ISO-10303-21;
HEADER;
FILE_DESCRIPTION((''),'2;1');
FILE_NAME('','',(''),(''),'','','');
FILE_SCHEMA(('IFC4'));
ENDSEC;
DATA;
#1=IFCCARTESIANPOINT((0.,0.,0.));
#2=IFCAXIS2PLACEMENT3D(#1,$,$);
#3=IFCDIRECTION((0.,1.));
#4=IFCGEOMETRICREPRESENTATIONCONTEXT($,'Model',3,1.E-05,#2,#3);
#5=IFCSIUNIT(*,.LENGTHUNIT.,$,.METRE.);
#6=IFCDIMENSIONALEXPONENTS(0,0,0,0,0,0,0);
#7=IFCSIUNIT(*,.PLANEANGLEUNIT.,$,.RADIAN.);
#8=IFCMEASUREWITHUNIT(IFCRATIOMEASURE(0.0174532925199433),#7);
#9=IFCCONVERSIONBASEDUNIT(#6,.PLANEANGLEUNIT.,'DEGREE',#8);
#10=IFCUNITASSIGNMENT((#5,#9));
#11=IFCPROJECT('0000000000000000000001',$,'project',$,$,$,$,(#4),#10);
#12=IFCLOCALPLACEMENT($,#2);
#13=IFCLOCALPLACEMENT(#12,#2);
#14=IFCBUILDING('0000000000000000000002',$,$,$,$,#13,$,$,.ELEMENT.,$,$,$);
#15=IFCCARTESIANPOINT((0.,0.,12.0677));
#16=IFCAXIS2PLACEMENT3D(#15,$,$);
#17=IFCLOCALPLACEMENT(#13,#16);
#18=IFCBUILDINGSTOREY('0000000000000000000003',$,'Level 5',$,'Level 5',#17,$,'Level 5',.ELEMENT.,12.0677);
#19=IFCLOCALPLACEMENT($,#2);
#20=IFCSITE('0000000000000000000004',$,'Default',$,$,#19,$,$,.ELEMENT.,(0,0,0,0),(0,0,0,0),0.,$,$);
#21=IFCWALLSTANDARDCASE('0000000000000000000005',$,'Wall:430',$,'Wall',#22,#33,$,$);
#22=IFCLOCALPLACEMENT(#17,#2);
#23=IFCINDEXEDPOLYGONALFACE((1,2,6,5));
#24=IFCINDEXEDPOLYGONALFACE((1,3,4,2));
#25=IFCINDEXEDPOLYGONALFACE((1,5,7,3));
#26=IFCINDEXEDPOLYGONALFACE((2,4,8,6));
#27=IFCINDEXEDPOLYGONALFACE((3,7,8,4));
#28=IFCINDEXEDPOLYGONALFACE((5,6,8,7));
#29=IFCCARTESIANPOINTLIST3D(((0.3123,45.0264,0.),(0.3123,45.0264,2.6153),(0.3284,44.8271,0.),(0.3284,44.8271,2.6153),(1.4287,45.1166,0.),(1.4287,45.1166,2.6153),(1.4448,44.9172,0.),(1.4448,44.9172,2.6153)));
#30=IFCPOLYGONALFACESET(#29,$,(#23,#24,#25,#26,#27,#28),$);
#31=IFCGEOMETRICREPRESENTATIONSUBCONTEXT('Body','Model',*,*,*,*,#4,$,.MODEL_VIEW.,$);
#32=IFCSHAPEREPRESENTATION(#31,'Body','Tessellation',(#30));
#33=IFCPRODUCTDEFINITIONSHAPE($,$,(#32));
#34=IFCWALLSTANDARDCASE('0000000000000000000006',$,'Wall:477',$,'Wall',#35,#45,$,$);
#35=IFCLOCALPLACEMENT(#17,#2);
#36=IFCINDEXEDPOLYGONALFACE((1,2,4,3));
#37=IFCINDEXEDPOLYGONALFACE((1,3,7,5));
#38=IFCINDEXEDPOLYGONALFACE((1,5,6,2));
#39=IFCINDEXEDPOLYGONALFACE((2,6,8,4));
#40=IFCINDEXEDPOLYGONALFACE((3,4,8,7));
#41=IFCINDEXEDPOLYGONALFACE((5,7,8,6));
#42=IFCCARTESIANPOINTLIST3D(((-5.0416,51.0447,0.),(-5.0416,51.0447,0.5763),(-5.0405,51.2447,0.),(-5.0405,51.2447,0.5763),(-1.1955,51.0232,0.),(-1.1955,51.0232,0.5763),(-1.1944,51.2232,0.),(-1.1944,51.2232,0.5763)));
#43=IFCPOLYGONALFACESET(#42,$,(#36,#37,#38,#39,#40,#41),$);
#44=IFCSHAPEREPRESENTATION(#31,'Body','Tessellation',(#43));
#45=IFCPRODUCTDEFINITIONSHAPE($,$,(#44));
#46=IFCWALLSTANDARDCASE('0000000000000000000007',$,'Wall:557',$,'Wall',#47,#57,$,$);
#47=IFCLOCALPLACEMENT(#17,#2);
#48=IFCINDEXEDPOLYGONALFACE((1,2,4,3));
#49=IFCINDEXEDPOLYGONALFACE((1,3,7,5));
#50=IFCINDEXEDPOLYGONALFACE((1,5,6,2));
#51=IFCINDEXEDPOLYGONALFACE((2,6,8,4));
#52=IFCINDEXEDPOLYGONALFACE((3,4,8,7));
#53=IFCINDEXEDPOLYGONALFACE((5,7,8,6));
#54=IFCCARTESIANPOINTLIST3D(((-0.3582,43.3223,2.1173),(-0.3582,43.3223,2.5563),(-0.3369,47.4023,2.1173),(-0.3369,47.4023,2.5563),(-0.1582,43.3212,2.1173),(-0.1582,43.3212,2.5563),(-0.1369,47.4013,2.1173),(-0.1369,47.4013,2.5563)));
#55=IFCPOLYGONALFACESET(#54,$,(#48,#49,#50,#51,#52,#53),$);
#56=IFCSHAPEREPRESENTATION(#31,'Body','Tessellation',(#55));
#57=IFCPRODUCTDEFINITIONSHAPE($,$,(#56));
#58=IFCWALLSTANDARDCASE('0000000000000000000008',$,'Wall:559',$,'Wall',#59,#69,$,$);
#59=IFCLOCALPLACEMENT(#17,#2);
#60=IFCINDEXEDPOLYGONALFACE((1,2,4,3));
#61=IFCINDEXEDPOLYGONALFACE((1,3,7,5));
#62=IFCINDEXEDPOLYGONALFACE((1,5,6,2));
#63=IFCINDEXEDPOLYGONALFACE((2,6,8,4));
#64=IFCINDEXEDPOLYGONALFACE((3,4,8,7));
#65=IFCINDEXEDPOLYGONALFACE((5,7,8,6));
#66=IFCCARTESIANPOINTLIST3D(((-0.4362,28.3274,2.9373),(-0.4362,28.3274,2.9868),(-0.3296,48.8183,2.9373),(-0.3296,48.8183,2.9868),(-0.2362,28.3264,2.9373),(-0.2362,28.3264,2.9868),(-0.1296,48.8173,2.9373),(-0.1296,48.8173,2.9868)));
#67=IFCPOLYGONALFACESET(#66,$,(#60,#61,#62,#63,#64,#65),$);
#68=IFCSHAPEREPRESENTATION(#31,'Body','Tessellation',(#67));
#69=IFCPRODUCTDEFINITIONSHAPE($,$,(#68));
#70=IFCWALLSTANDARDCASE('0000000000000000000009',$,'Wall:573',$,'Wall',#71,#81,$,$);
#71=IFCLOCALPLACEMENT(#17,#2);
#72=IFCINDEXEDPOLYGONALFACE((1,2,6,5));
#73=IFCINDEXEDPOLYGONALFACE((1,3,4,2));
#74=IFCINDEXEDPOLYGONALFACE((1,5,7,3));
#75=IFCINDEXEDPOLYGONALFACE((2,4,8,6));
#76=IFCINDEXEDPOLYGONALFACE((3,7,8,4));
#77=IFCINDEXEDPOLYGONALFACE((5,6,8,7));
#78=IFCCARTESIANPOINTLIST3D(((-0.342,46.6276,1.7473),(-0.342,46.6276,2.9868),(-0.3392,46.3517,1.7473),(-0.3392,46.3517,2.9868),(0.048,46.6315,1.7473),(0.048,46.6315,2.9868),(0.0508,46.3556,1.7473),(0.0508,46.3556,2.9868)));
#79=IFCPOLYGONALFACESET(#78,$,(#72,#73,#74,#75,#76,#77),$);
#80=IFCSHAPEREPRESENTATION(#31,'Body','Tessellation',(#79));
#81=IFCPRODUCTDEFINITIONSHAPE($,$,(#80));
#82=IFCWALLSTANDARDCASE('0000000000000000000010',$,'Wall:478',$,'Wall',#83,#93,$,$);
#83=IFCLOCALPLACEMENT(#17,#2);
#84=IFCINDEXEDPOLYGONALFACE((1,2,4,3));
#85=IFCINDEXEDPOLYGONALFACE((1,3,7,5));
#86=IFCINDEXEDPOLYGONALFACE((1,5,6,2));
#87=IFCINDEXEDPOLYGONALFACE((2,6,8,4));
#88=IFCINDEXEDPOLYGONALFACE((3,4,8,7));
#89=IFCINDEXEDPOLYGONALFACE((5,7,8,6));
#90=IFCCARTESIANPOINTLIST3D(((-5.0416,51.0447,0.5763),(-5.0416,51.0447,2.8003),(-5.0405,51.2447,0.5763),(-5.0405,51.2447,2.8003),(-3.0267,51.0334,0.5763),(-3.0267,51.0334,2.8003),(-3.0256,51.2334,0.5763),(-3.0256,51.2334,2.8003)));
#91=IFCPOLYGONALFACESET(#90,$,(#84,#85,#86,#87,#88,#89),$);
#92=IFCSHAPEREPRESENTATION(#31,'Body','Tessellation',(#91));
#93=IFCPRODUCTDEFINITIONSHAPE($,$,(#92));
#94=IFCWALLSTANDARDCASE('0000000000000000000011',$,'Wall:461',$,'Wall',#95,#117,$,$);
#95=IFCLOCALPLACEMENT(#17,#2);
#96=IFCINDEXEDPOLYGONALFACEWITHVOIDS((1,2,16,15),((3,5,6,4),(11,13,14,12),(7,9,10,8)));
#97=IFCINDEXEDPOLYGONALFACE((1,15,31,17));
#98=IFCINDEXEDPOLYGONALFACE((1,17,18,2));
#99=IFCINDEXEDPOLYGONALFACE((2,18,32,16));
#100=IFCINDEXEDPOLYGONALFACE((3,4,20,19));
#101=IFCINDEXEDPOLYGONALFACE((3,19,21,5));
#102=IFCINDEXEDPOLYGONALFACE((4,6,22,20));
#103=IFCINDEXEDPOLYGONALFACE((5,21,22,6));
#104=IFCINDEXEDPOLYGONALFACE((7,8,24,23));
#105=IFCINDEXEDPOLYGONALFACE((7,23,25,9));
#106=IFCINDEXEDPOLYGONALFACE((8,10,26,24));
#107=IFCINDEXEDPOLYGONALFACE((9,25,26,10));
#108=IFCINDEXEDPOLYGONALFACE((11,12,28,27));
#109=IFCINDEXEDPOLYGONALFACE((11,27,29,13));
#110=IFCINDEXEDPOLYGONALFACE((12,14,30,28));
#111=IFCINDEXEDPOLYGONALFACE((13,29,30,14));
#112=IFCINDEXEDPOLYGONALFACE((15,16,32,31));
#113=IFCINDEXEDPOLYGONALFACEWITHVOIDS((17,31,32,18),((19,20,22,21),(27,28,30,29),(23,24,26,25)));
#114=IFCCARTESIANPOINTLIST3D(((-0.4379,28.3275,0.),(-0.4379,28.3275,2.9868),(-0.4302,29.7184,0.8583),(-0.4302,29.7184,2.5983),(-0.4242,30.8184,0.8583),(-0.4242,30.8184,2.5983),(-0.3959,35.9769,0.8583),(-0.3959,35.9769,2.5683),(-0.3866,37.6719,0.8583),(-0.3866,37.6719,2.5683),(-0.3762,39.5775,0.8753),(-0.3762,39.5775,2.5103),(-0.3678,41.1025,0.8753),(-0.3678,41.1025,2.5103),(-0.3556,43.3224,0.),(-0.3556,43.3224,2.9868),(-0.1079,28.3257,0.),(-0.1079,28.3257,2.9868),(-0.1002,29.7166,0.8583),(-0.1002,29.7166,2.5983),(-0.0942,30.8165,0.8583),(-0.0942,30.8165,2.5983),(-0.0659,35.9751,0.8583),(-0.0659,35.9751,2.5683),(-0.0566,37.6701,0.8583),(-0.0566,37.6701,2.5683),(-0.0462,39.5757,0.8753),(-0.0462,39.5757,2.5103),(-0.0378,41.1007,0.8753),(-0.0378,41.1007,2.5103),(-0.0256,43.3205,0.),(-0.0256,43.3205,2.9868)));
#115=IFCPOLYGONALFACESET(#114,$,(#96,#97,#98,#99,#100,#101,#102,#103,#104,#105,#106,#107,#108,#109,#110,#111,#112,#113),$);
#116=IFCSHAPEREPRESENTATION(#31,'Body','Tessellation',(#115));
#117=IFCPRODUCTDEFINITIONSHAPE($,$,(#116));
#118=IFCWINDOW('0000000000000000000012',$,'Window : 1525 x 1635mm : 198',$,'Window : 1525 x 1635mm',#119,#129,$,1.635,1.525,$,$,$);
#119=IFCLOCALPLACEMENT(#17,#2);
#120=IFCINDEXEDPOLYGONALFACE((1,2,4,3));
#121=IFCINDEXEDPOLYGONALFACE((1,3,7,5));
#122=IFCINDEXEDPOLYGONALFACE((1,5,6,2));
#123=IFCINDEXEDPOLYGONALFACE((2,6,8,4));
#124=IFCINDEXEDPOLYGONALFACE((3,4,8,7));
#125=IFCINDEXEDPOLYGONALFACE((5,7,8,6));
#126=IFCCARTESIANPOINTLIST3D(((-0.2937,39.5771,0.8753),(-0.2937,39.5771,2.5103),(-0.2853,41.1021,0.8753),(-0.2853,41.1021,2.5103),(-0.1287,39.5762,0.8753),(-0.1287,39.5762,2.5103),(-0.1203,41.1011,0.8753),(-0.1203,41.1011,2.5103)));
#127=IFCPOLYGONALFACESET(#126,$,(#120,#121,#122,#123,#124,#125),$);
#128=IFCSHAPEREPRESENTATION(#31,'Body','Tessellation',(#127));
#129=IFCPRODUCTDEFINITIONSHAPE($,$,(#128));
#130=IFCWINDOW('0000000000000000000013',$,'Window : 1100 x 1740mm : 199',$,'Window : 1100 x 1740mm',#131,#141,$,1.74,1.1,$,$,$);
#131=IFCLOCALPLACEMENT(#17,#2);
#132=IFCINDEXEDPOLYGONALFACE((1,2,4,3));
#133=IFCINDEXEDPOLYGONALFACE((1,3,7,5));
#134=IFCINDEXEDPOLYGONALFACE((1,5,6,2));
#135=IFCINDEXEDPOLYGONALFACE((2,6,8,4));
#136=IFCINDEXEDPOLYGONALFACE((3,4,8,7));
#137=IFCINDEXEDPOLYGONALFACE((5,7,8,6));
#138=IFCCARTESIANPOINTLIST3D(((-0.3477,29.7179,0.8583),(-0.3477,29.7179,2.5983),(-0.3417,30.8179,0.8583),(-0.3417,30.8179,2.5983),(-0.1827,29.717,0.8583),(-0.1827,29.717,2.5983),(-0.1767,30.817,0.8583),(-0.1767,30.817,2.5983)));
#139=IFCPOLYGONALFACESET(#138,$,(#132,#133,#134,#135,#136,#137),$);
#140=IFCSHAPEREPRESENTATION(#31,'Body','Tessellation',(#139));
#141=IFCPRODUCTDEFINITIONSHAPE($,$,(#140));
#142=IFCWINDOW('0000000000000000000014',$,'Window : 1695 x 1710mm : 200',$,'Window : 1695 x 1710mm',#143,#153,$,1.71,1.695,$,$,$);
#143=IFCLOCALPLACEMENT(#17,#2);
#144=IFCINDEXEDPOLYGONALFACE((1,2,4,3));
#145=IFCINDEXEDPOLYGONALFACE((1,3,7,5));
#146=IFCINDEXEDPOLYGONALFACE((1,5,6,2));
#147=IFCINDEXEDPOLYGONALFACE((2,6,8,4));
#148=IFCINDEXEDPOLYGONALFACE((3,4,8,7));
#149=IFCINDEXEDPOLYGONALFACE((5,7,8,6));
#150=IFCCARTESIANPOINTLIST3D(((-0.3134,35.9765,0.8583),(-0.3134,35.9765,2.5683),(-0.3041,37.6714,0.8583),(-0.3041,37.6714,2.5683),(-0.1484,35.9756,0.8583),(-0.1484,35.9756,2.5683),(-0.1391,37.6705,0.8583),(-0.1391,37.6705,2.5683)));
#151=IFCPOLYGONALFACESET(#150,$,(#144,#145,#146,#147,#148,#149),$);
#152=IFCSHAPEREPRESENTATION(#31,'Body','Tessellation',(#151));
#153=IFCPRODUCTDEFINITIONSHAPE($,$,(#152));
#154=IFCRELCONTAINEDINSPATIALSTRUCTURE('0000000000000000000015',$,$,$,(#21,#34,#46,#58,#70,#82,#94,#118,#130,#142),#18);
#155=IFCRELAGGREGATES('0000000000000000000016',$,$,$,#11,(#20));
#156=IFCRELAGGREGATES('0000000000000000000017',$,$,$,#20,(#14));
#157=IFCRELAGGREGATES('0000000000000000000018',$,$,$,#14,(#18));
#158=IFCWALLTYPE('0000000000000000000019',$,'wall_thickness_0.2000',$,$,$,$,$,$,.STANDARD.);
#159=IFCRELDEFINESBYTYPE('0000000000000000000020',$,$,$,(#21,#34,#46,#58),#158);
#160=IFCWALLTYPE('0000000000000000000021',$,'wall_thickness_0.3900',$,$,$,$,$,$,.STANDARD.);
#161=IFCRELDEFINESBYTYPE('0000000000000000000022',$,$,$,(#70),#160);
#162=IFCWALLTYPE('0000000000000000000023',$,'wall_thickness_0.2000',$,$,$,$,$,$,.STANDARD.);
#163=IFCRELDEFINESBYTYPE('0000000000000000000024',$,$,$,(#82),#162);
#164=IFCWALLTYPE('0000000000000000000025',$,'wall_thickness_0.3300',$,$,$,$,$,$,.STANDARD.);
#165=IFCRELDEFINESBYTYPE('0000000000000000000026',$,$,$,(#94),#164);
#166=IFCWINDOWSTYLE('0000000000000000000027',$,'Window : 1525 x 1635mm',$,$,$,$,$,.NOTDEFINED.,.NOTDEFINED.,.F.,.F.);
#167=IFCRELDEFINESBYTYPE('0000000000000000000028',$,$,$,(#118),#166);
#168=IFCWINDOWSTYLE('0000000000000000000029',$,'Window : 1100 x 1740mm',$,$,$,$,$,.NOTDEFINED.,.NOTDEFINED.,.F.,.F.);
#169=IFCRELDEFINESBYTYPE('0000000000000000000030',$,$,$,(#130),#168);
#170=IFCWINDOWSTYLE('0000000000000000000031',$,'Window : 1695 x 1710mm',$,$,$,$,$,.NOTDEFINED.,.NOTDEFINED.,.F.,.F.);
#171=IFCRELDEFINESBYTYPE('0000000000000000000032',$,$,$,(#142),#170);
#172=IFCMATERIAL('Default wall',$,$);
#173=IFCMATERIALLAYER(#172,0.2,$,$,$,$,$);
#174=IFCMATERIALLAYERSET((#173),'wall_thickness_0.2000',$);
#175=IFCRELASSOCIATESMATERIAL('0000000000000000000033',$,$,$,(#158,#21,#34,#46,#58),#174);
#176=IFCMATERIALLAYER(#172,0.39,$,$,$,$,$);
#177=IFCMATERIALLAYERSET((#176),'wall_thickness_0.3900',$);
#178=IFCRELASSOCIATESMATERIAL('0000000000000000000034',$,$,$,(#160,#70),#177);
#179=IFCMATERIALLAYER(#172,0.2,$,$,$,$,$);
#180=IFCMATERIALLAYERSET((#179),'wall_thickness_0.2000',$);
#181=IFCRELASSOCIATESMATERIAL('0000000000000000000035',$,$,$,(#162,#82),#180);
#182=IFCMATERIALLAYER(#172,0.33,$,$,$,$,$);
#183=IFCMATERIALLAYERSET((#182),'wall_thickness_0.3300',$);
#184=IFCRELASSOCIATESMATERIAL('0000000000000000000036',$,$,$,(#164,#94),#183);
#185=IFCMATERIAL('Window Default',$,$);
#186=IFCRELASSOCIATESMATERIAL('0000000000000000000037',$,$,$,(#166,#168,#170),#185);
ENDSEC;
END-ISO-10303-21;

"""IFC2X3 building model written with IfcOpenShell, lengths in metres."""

from ifc_helpers import new_model, entity, si_unit, converted_unit, direction, frame, frame_2d, origin, origin_2d_with_axis, place, context, subcontext, project, spatial, polyline, rectangle, outline, extrude, source, transform, mapped, material, layer, layer_set, layer_usage, type_object, type_shapes, element, fill, save


model = new_model("IFC2X3")

# Units and contexts
model_context = context("Model", 3, precision=1e-05, world=origin(), true_north=direction((0.0, 1.0)))
body_context = subcontext(model_context, "Body", "Model", "MODEL_VIEW")
ifc_project = project(units=[si_unit("LENGTHUNIT", "METRE"), converted_unit("PLANEANGLEUNIT", "DEGREE", entity("IfcRatioMeasure", 0.0174532925199433), si_unit("PLANEANGLEUNIT", "RADIAN"), dimensions=[0, 0, 0, 0, 0, 0, 0])], contexts=[model_context])

# Site, building, storey
site_placement = place(None, origin())
site = spatial("IfcSite", under=ifc_project, at=site_placement, Name="Default", CompositionType="ELEMENT", RefLatitude=(0, 0, 0, 0), RefLongitude=(0, 0, 0, 0), RefElevation=0.0)
placement_1 = place(None, origin())
building_placement = place(placement_1, origin())
building = spatial("IfcBuilding", under=site, at=building_placement, CompositionType="ELEMENT")
storey_placement = place(building_placement, frame((0.0, 0.0, 12.0677)))
storey = spatial("IfcBuildingStorey", under=building, at=storey_placement, Name="Level 5", ObjectType="Level 5", LongName="Level 5", CompositionType="ELEMENT", Elevation=12.0677)

# Walls
ifc_material_1 = material(Name="Default wall")
ifc_layer_1 = layer(ifc_material_1, 0.2)
ifc_layer_set_1 = layer_set([ifc_layer_1], Name="wall_thickness_0.2000")
ifc_layer_usage_1 = layer_usage(ifc_layer_set_1, "AXIS2", "POSITIVE", -0.1)
wall_type_1 = type_object("IfcWallType", Name="wall_thickness_0.2000", PredefinedType="STANDARD", material=ifc_layer_set_1)
wall_1_placement = place(storey_placement, frame((0.3203, 44.9268, 0.0), z_axis=(0.0, 0.0, 1.0), x_axis=(0.996755, 0.080497, 0.0)))
element("IfcWallStandardCase", 1, at=wall_1_placement, inside=storey, type_object=wall_type_1, material=ifc_layer_usage_1, Name="Wall:430", ObjectType="Wall", context=body_context, shape_type="SweptSolid", body=[
    extrude(outline(polyline([(1.1201, -0.1), (1.1201, 0.1), (0.0, 0.1), (0.0, -0.1), (1.1201, -0.1)])), origin(), (0.0, 0.0, 1.0), 2.6153),
])
wall_2_placement = place(storey_placement, frame((-5.041, 51.1447, 0.0), z_axis=(0.0, 0.0, 1.0), x_axis=(0.999984, -0.005584, 0.0)))
element("IfcWallStandardCase", 2, at=wall_2_placement, inside=storey, type_object=wall_type_1, material=ifc_layer_usage_1, Name="Wall:477", ObjectType="Wall", context=body_context, shape_type="SweptSolid", body=[
    extrude(outline(polyline([(3.8461, -0.1), (3.8461, 0.1), (0.0, 0.1), (0.0, -0.1), (3.8461, -0.1)])), origin(), (0.0, 0.0, 1.0), 0.5763),
])
placement_2 = place(building_placement, frame((0.0, 0.0, 14.185)))
wall_3_placement = place(placement_2, frame((-0.2369, 47.4018, 0.0), z_axis=(0.0, 0.0, 1.0), x_axis=(-0.005207, -0.999986, 0.0)))
element("IfcWallStandardCase", 3, at=wall_3_placement, inside=storey, type_object=wall_type_1, material=ifc_layer_usage_1, Name="Wall:557", ObjectType="Wall", context=body_context, shape_type="SweptSolid", body=[
    extrude(outline(polyline([(4.0801, -0.1), (4.0801, 0.1), (0.0, 0.1), (0.0, -0.1), (4.0801, -0.1)])), origin(), (0.0, 0.0, 1.0), 0.439),
])
placement_3 = place(building_placement, frame((0.0, 0.0, 15.005)))
wall_4_placement = place(placement_3, frame((-0.2296, 48.8178, 0.0), z_axis=(0.0, 0.0, 1.0), x_axis=(-0.005207, -0.999986, 0.0)))
element("IfcWallStandardCase", 4, at=wall_4_placement, inside=storey, type_object=wall_type_1, material=ifc_layer_usage_1, Name="Wall:559", ObjectType="Wall", context=body_context, shape_type="SweptSolid", body=[
    extrude(outline(polyline([(20.4912, -0.1), (20.4912, 0.1), (0.0, 0.1), (0.0, -0.1), (20.4912, -0.1)])), origin(), (0.0, 0.0, 1.0), 0.0495),
])
ifc_layer_2 = layer(ifc_material_1, 0.39)
ifc_layer_set_2 = layer_set([ifc_layer_2], Name="wall_thickness_0.3900")
ifc_layer_usage_2 = layer_usage(ifc_layer_set_2, "AXIS2", "POSITIVE", -0.195)
wall_type_2 = type_object("IfcWallType", Name="wall_thickness_0.3900", PredefinedType="STANDARD", material=ifc_layer_set_2)
placement_4 = place(building_placement, frame((0.0, 0.0, 13.815)))
wall_5_placement = place(placement_4, frame((-0.147, 46.6296, 0.0), z_axis=(0.0, 0.0, 1.0), x_axis=(0.01007, -0.999949, 0.0)))
element("IfcWallStandardCase", 5, at=wall_5_placement, inside=storey, type_object=wall_type_2, material=ifc_layer_usage_2, Name="Wall:573", ObjectType="Wall", context=body_context, shape_type="SweptSolid", body=[
    extrude(outline(polyline([(0.276, -0.195), (0.276, 0.195), (0.0, 0.195), (0.0, -0.195), (0.276, -0.195)])), origin(), (0.0, 0.0, 1.0), 1.2395),
])
ifc_layer_3 = layer(ifc_material_1, 0.2)
ifc_layer_set_3 = layer_set([ifc_layer_3], Name="wall_thickness_0.2000")
ifc_layer_usage_3 = layer_usage(ifc_layer_set_3, "AXIS2", "POSITIVE", -0.1)
wall_type_3 = type_object("IfcWallType", Name="wall_thickness_0.2000", PredefinedType="STANDARD", material=ifc_layer_set_3)
placement_5 = place(building_placement, frame((0.0, 0.0, 12.644)))
wall_6_placement = place(placement_5, frame((-5.041, 51.1447, 0.0), z_axis=(0.0, 0.0, 1.0), x_axis=(0.999984, -0.005585, 0.0)))
element("IfcWallStandardCase", 6, at=wall_6_placement, inside=storey, type_object=wall_type_3, material=ifc_layer_usage_3, Name="Wall:478", ObjectType="Wall", context=body_context, shape_type="SweptSolid", body=[
    extrude(outline(polyline([(2.0149, -0.1), (2.0149, 0.1), (0.0, 0.1), (0.0, -0.1), (2.0149, -0.1)])), origin(), (0.0, 0.0, 1.0), 2.224),
])

# Wall, openings, windows
ifc_layer_4 = layer(ifc_material_1, 0.33)
ifc_layer_set_4 = layer_set([ifc_layer_4], Name="wall_thickness_0.3300")
ifc_layer_usage_4 = layer_usage(ifc_layer_set_4, "AXIS2", "POSITIVE", -0.165)
wall_type_4 = type_object("IfcWallType", Name="wall_thickness_0.3300", PredefinedType="STANDARD", material=ifc_layer_set_4)
wall_7_placement = place(storey_placement, frame((-0.1906, 43.3215, 0.0), z_axis=(0.0, 0.0, 1.0), x_axis=(-0.005485, -0.999985, 0.0)))
wall_7 = element("IfcWallStandardCase", 7, at=wall_7_placement, inside=storey, type_object=wall_type_4, material=ifc_layer_usage_4, Name="Wall:461", ObjectType="Wall", context=body_context, shape_type="SweptSolid", body=[
    extrude(outline(polyline([(14.995, -0.165), (14.995, 0.165), (0.0, 0.165), (0.0, -0.165), (14.995, -0.165)])), origin(), (0.0, 0.0, 1.0), 2.9868),
])
opening_1_placement = place(wall_7_placement, frame((2.2199, -0.165, 0.8753)))
opening_1 = element("IfcOpeningElement", 8, at=opening_1_placement, cuts=wall_7, ObjectType="Opening", context=body_context, shape_type="SweptSolid", body=[
    extrude(rectangle(XDim=1.525, YDim=1.635, at=frame_2d((0.8175, 0.7625), x_axis=(0.0, 1.0))), frame((0.0, 0.0, 0.0), z_axis=(0.0, 1.0, 0.0), x_axis=(0.0, 0.0, 1.0)), (0.0, 0.0, 1.0), 0.33),
])
opening_2_placement = place(wall_7_placement, frame((12.5042, -0.165, 0.8583)))
opening_2 = element("IfcOpeningElement", 9, at=opening_2_placement, cuts=wall_7, ObjectType="Opening", context=body_context, shape_type="SweptSolid", body=[
    extrude(rectangle(XDim=1.1, YDim=1.74, at=frame_2d((0.87, 0.55), x_axis=(0.0, 1.0))), frame((0.0, 0.0, 0.0), z_axis=(0.0, 1.0, 0.0), x_axis=(0.0, 0.0, 1.0)), (0.0, 0.0, 1.0), 0.33),
])
opening_3_placement = place(wall_7_placement, frame((5.6505, -0.165, 0.8583)))
opening_3 = element("IfcOpeningElement", 10, at=opening_3_placement, cuts=wall_7, ObjectType="Opening", context=body_context, shape_type="SweptSolid", body=[
    extrude(rectangle(XDim=1.695, YDim=1.71, at=frame_2d((0.855, 0.8475), x_axis=(0.0, 1.0))), frame((0.0, 0.0, 0.0), z_axis=(0.0, 1.0, 0.0), x_axis=(0.0, 0.0, 1.0)), (0.0, 0.0, 1.0), 0.33),
])
ifc_material_2 = material(Name="Window Default")
window_style_1 = type_object("IfcWindowStyle", Name="Window : 1525 x 1635mm", ConstructionType="NOTDEFINED", OperationType="NOTDEFINED", ParameterTakesPrecedence=False, Sizeable=False, material=ifc_material_2)
shared_shape_1 = source(origin(), body_context, "Body", "SweptSolid", [
    extrude(rectangle(XDim=0.165, YDim=1.525, at=origin_2d_with_axis()), frame((0.7625, 0.165, 0.0), z_axis=(0.0, 0.0, 1.0), x_axis=(0.0, 1.0, 0.0)), (0.0, 0.0, 1.0), 1.635),
])
type_shapes(window_style_1, [shared_shape_1])
window_1_placement = place(opening_1_placement, origin())
window_1 = element("IfcWindow", 11, at=window_1_placement, inside=storey, type_object=window_style_1, Name="Window : 1525 x 1635mm : 198", ObjectType="Window : 1525 x 1635mm", OverallHeight=1.635, OverallWidth=1.525, context=body_context, shape_type="MappedRepresentation", body=[
    mapped(shared_shape_1, transform((0.0, 0.0, 0.0), scale=1.0)),
])
fill(opening_1, window_1)
window_style_2 = type_object("IfcWindowStyle", Name="Window : 1100 x 1740mm", ConstructionType="NOTDEFINED", OperationType="NOTDEFINED", ParameterTakesPrecedence=False, Sizeable=False, material=ifc_material_2)
shared_shape_2 = source(origin(), body_context, "Body", "SweptSolid", [
    extrude(rectangle(XDim=0.165, YDim=1.1, at=origin_2d_with_axis()), frame((0.55, 0.165, 0.0), z_axis=(0.0, 0.0, 1.0), x_axis=(0.0, 1.0, 0.0)), (0.0, 0.0, 1.0), 1.74),
])
type_shapes(window_style_2, [shared_shape_2])
window_2_placement = place(opening_2_placement, origin())
window_2 = element("IfcWindow", 12, at=window_2_placement, inside=storey, type_object=window_style_2, Name="Window : 1100 x 1740mm : 199", ObjectType="Window : 1100 x 1740mm", OverallHeight=1.74, OverallWidth=1.1, context=body_context, shape_type="MappedRepresentation", body=[
    mapped(shared_shape_2, transform((0.0, 0.0, 0.0), scale=1.0)),
])
fill(opening_2, window_2)
window_style_3 = type_object("IfcWindowStyle", Name="Window : 1695 x 1710mm", ConstructionType="NOTDEFINED", OperationType="NOTDEFINED", ParameterTakesPrecedence=False, Sizeable=False, material=ifc_material_2)
shared_shape_3 = source(origin(), body_context, "Body", "SweptSolid", [
    extrude(rectangle(XDim=0.165, YDim=1.695, at=origin_2d_with_axis()), frame((0.8475, 0.165, 0.0), z_axis=(0.0, 0.0, 1.0), x_axis=(0.0, 1.0, 0.0)), (0.0, 0.0, 1.0), 1.71),
])
type_shapes(window_style_3, [shared_shape_3])
window_3_placement = place(opening_3_placement, origin())
window_3 = element("IfcWindow", 13, at=window_3_placement, inside=storey, type_object=window_style_3, Name="Window : 1695 x 1710mm : 200", ObjectType="Window : 1695 x 1710mm", OverallHeight=1.71, OverallWidth=1.695, context=body_context, shape_type="MappedRepresentation", body=[
    mapped(shared_shape_3, transform((0.0, 0.0, 0.0), scale=1.0)),
])
fill(opening_3, window_3)

save(model, "model.ifc")
